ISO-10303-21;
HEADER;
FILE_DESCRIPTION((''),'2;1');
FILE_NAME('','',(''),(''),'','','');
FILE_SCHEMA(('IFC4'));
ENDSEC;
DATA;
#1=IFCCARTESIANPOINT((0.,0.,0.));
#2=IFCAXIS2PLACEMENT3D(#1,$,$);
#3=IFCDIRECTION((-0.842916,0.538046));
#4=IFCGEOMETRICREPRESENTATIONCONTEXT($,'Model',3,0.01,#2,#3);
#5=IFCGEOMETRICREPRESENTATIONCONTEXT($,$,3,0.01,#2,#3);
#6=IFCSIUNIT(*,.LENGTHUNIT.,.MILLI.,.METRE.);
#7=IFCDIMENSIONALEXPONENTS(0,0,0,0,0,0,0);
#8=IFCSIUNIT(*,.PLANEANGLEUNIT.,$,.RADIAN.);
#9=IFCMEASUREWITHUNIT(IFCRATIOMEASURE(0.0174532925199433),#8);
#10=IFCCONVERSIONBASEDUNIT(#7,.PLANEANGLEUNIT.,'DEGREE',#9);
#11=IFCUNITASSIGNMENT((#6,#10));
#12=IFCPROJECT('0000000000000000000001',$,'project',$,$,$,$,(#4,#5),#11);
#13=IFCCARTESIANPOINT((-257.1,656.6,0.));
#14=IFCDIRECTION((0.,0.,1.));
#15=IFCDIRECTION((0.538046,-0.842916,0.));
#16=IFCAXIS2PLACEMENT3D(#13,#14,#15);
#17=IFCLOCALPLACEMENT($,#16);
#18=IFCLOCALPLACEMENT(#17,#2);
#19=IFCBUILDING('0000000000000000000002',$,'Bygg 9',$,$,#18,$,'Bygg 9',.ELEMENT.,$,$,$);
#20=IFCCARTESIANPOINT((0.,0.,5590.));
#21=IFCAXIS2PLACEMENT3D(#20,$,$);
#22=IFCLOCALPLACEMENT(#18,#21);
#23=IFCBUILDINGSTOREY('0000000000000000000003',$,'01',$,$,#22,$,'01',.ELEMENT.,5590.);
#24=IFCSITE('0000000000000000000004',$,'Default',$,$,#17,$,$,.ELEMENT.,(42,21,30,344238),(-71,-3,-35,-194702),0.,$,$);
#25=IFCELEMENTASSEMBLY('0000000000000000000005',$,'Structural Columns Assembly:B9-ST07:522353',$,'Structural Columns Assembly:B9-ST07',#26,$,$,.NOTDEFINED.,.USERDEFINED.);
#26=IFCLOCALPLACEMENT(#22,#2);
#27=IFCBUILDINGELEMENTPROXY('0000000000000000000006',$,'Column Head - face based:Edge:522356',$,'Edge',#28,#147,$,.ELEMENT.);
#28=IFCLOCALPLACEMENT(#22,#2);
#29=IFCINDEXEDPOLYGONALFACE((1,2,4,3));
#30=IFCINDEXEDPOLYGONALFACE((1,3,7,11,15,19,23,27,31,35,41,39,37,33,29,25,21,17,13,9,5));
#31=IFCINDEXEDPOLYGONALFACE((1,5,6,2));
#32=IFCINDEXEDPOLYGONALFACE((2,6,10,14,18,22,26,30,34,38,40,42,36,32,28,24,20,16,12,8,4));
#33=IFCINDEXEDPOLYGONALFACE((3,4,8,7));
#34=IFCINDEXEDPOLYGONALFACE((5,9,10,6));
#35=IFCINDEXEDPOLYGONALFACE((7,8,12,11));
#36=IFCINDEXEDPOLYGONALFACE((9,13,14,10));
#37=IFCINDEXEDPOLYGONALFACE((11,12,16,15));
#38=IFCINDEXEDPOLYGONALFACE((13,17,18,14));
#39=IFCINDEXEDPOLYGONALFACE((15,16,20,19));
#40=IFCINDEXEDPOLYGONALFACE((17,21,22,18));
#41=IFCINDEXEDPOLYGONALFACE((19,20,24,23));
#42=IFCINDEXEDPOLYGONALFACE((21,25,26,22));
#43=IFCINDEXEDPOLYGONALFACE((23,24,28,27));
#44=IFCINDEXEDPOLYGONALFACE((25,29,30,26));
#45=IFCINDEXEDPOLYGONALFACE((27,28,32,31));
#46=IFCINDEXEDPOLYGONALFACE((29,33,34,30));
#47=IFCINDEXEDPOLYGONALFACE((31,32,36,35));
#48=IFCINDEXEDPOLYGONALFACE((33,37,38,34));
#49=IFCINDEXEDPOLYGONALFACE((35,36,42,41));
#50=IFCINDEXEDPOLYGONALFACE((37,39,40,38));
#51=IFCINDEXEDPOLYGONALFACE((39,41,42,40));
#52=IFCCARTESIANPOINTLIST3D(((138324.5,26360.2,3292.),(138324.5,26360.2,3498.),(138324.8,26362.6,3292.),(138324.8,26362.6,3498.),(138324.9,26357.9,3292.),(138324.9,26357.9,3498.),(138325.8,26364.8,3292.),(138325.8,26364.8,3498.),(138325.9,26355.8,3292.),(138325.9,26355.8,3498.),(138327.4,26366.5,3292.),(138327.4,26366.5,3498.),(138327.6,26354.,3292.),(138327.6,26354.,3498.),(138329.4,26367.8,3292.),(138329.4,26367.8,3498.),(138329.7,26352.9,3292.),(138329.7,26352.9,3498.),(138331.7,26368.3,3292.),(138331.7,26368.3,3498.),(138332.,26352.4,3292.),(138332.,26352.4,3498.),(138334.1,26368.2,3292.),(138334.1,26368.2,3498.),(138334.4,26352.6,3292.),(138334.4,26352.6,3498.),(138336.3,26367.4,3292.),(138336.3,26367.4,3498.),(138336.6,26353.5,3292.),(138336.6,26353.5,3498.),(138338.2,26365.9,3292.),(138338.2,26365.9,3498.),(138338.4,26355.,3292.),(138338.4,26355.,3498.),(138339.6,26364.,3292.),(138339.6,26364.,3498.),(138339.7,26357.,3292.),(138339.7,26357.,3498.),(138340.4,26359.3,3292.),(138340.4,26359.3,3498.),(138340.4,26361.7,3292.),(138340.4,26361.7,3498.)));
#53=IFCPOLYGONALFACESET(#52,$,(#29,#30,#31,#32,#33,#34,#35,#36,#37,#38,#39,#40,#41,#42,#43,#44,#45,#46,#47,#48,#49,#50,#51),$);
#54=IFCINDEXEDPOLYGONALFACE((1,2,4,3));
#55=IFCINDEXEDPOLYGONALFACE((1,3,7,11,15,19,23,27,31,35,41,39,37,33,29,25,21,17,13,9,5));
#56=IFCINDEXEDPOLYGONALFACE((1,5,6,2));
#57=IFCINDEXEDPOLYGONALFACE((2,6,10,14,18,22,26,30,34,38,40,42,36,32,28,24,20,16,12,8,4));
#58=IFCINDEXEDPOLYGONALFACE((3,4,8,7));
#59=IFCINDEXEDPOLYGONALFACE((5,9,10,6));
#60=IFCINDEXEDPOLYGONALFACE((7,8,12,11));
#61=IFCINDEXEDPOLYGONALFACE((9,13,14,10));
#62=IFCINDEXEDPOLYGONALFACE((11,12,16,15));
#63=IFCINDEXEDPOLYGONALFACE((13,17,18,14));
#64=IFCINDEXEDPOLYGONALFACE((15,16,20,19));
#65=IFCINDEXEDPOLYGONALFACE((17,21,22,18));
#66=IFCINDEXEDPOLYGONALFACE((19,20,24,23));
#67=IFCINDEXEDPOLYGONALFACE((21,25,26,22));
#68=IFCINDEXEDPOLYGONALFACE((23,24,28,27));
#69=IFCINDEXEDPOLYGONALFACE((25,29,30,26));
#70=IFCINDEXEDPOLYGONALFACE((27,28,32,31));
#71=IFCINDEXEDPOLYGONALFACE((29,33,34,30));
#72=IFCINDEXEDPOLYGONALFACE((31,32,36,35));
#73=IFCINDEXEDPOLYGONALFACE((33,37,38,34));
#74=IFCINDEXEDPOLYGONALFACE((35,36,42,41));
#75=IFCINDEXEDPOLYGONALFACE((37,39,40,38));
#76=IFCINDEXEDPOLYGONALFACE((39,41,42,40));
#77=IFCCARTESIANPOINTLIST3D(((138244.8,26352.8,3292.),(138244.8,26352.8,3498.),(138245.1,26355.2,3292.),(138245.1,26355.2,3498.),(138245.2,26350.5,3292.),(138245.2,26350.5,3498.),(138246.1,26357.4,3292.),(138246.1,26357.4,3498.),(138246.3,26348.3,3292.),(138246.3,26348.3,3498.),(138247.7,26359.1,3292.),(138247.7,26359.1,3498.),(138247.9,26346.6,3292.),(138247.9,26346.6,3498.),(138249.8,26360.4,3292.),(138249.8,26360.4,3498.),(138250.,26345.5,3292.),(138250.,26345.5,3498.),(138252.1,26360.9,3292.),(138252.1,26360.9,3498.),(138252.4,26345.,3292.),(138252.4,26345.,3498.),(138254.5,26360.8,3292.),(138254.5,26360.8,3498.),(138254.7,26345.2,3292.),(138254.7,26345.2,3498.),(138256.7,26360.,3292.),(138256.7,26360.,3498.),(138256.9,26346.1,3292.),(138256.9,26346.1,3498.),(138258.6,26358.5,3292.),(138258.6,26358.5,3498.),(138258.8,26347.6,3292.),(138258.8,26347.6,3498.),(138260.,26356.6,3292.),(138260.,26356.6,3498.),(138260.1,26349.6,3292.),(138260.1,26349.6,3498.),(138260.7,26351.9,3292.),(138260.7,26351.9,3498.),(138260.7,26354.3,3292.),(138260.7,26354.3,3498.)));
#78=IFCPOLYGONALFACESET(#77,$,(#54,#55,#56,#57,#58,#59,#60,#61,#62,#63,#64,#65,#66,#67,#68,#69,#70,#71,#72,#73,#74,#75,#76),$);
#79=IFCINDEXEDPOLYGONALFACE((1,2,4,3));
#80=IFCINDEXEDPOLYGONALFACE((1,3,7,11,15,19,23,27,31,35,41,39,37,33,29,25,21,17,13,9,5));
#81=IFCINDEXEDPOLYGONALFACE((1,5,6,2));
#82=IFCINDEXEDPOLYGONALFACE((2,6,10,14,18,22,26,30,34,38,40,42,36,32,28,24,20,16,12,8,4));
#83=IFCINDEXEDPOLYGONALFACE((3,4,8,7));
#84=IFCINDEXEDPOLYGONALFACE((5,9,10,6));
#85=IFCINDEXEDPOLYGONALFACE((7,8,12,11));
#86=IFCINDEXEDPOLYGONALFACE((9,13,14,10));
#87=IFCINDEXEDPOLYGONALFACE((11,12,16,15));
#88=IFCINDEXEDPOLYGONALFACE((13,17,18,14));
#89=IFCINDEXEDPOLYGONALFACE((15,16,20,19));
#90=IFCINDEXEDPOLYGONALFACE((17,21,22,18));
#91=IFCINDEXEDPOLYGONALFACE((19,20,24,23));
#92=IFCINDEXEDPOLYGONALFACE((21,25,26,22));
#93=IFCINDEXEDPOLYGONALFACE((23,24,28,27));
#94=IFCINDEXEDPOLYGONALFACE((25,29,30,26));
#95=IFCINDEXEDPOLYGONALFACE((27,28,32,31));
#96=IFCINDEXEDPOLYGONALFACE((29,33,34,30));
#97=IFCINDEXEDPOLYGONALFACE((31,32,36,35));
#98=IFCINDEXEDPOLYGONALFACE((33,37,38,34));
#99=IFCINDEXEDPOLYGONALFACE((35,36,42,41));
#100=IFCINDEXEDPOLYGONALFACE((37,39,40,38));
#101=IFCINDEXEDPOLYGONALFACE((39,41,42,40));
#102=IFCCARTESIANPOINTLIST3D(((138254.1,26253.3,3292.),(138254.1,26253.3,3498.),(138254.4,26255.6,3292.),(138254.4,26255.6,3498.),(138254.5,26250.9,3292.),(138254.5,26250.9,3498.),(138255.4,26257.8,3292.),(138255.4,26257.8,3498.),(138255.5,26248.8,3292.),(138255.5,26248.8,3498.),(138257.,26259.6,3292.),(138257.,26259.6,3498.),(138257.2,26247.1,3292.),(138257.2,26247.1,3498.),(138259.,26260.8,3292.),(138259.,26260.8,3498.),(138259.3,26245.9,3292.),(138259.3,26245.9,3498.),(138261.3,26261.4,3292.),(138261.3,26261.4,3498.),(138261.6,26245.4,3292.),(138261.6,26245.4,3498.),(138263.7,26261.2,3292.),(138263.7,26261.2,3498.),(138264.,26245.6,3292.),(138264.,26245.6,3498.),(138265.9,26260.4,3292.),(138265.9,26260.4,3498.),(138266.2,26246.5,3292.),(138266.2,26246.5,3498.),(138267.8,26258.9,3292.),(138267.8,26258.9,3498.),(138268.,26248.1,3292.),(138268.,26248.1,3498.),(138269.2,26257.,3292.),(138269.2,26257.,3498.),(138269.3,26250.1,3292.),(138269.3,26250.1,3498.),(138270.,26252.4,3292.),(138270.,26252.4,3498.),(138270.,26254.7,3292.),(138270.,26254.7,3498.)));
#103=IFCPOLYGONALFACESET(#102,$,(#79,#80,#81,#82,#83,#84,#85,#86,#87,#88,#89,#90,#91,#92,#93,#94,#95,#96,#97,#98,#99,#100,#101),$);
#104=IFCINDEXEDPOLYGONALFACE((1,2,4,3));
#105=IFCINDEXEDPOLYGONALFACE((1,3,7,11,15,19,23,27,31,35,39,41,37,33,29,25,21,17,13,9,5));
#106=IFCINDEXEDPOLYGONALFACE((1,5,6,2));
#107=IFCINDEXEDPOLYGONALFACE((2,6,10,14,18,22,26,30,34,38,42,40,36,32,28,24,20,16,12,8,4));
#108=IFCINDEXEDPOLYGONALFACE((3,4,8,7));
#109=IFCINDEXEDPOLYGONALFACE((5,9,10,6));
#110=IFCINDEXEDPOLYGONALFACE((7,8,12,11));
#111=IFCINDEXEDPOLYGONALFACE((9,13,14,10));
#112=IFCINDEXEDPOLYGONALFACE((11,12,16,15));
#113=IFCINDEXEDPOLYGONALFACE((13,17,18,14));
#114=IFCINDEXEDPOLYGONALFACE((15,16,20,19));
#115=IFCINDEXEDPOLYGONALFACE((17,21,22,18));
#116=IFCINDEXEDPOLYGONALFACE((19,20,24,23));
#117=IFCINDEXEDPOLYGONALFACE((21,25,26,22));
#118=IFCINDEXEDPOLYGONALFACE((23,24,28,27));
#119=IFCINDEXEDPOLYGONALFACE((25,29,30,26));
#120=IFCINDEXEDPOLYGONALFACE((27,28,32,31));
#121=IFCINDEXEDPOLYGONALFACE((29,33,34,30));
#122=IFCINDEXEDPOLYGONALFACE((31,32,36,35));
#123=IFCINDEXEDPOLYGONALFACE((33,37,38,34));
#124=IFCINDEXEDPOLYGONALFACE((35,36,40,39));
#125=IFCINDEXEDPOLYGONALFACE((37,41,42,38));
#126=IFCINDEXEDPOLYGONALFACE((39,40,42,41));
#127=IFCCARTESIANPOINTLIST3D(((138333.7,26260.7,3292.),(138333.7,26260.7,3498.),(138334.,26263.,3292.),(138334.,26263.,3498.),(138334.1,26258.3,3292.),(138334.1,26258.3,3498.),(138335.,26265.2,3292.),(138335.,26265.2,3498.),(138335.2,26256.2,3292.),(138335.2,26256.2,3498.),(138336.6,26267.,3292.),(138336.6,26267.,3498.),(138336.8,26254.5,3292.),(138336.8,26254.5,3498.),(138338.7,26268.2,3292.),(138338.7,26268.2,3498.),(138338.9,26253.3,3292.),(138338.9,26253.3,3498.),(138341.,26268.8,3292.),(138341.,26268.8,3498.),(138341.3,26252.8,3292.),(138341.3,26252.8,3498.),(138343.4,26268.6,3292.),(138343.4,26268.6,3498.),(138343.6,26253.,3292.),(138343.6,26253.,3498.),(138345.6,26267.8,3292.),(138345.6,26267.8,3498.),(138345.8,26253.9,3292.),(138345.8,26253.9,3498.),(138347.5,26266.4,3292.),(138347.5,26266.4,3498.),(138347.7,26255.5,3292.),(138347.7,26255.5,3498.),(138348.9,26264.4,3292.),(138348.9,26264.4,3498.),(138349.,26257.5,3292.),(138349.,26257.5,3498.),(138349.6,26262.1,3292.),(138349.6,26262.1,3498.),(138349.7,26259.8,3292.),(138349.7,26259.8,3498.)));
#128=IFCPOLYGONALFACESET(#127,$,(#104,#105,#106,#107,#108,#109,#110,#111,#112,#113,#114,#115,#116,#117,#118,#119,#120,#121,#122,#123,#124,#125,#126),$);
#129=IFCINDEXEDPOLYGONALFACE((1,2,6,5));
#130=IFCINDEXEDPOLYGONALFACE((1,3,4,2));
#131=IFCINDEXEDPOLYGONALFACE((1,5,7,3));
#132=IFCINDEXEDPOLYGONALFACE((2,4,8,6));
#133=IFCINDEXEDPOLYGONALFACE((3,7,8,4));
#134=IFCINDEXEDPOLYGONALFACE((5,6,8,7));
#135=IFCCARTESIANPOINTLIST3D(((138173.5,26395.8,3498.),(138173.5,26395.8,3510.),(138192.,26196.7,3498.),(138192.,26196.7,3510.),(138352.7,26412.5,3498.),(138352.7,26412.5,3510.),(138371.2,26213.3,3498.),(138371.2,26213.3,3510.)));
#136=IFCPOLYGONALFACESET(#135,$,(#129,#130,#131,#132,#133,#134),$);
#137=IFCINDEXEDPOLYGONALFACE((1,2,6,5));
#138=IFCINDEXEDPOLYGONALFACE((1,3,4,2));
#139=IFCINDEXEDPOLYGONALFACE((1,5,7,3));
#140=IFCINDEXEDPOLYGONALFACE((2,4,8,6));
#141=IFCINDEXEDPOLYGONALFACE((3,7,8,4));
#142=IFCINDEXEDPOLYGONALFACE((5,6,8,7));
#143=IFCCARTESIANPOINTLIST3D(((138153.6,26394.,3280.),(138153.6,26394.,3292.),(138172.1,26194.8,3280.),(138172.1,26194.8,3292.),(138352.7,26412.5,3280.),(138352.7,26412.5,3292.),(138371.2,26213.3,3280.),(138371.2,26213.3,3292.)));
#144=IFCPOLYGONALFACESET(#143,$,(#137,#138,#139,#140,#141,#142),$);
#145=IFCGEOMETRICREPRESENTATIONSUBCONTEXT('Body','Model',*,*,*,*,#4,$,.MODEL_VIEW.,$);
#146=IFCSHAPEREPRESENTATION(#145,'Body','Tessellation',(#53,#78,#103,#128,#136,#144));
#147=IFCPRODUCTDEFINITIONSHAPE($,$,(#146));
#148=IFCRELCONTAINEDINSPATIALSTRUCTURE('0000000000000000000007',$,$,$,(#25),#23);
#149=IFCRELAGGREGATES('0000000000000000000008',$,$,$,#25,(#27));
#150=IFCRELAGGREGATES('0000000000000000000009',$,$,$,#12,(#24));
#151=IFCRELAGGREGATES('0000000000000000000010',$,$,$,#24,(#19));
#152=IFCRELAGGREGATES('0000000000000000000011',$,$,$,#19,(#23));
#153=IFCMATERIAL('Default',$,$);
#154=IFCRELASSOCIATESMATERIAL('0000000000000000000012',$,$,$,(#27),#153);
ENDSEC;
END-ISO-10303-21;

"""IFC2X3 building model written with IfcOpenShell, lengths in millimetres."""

from ifc_helpers import new_model, entity, si_unit, converted_unit, direction, frame, frame_2d, origin, origin_2d_with_axis, place, context, subcontext, project, spatial, rectangle, circle, extrude, source, transform, mapped, material, element, aggregate, save


model = new_model("IFC2X3")

# Units and contexts
model_context = context("Model", 3, precision=0.01, world=origin(), true_north=direction((-0.842916, 0.538046)))
context_of_model = context(None, 3, precision=0.01, world=origin(), true_north=direction((-0.842916, 0.538046)))
body_context = subcontext(model_context, "Body", "Model", "MODEL_VIEW")
ifc_project = project(units=[si_unit("LENGTHUNIT", "METRE", prefix="MILLI"), converted_unit("PLANEANGLEUNIT", "DEGREE", entity("IfcRatioMeasure", 0.0174532925199433), si_unit("PLANEANGLEUNIT", "RADIAN"), dimensions=[0, 0, 0, 0, 0, 0, 0])], contexts=[model_context, context_of_model])

# Site, building, storey
site_placement = place(None, frame((-257.1, 656.6, 0.0), z_axis=(0.0, 0.0, 1.0), x_axis=(0.538046, -0.842916, 0.0)))
site = spatial("IfcSite", under=ifc_project, at=site_placement, Name="Default", CompositionType="ELEMENT", RefLatitude=(42, 21, 30, 344238), RefLongitude=(-71, -3, -35, -194702), RefElevation=0.0)
building_placement = place(site_placement, origin())
building = spatial("IfcBuilding", under=site, at=building_placement, Name="Bygg 9", LongName="Bygg 9", CompositionType="ELEMENT")
storey_placement = place(building_placement, frame((0.0, 0.0, 5590.0)))
storey = spatial("IfcBuildingStorey", under=building, at=storey_placement, Name="01", LongName="01", CompositionType="ELEMENT", Elevation=5590.0)

# Element assembly, building element proxy
ifc_material_1 = material(Name="Default")
shared_shape_1 = source(origin(), body_context, "Body", "SweptSolid", [
    extrude(circle(Radius=8.0, at=frame_2d((0.0, 0.0), x_axis=(1.0, 0.0))), frame((50.0, -135.0, 12.0)), (0.0, 0.0, 1.0), 206.0),
    extrude(circle(Radius=8.0, at=frame_2d((0.0, 0.0), x_axis=(1.0, 0.0))), frame((50.0, -55.0, 12.0)), (0.0, 0.0, 1.0), 206.0),
    extrude(circle(Radius=8.0, at=frame_2d((0.0, 0.0), x_axis=(1.0, 0.0))), frame((-50.0, -55.0, 12.0)), (0.0, 0.0, 1.0), 206.0),
    extrude(circle(Radius=8.0, at=frame_2d((0.0, 0.0), x_axis=(1.0, 0.0))), frame((-50.0, -135.0, 12.0)), (0.0, 0.0, 1.0), 206.0),
    extrude(rectangle(XDim=200.0, YDim=180.0, at=origin_2d_with_axis()), frame((0.0, -70.0, 218.0), z_axis=(0.0, 0.0, 1.0), x_axis=(-1.0, 0.0, 0.0)), (0.0, 0.0, 1.0), 12.0),
    extrude(rectangle(XDim=200.0, YDim=200.0, at=origin_2d_with_axis()), frame((0.0, -60.0, 0.0), z_axis=(0.0, 0.0, 1.0), x_axis=(0.0, 1.0, 0.0)), (0.0, 0.0, 1.0), 12.0),
])
assembly_1_placement = place(storey_placement, origin())
assembly_1 = element("IfcElementAssembly", 1, at=assembly_1_placement, inside=storey, Name="Structural Columns Assembly:B9-ST07:522353", ObjectType="Structural Columns Assembly:B9-ST07", AssemblyPlace="NOTDEFINED", PredefinedType="USERDEFINED")
proxy_1_placement = place(assembly_1_placement, frame((138202.7, 26298.1, 3280.0), z_axis=(0.0, 0.0, 1.0), x_axis=(-0.092535, 0.995709, 0.0)))
proxy_1 = element("IfcBuildingElementProxy", 2, at=proxy_1_placement, material=ifc_material_1, Name="Column Head - face based:Edge:522356", ObjectType="Edge", CompositionType="ELEMENT", context=body_context, shape_type="MappedRepresentation", body=[
    mapped(shared_shape_1, transform((0.0, 0.0, 0.0), scale=1.0)),
])
aggregate(assembly_1, [proxy_1])

save(model, "model.ifc")
